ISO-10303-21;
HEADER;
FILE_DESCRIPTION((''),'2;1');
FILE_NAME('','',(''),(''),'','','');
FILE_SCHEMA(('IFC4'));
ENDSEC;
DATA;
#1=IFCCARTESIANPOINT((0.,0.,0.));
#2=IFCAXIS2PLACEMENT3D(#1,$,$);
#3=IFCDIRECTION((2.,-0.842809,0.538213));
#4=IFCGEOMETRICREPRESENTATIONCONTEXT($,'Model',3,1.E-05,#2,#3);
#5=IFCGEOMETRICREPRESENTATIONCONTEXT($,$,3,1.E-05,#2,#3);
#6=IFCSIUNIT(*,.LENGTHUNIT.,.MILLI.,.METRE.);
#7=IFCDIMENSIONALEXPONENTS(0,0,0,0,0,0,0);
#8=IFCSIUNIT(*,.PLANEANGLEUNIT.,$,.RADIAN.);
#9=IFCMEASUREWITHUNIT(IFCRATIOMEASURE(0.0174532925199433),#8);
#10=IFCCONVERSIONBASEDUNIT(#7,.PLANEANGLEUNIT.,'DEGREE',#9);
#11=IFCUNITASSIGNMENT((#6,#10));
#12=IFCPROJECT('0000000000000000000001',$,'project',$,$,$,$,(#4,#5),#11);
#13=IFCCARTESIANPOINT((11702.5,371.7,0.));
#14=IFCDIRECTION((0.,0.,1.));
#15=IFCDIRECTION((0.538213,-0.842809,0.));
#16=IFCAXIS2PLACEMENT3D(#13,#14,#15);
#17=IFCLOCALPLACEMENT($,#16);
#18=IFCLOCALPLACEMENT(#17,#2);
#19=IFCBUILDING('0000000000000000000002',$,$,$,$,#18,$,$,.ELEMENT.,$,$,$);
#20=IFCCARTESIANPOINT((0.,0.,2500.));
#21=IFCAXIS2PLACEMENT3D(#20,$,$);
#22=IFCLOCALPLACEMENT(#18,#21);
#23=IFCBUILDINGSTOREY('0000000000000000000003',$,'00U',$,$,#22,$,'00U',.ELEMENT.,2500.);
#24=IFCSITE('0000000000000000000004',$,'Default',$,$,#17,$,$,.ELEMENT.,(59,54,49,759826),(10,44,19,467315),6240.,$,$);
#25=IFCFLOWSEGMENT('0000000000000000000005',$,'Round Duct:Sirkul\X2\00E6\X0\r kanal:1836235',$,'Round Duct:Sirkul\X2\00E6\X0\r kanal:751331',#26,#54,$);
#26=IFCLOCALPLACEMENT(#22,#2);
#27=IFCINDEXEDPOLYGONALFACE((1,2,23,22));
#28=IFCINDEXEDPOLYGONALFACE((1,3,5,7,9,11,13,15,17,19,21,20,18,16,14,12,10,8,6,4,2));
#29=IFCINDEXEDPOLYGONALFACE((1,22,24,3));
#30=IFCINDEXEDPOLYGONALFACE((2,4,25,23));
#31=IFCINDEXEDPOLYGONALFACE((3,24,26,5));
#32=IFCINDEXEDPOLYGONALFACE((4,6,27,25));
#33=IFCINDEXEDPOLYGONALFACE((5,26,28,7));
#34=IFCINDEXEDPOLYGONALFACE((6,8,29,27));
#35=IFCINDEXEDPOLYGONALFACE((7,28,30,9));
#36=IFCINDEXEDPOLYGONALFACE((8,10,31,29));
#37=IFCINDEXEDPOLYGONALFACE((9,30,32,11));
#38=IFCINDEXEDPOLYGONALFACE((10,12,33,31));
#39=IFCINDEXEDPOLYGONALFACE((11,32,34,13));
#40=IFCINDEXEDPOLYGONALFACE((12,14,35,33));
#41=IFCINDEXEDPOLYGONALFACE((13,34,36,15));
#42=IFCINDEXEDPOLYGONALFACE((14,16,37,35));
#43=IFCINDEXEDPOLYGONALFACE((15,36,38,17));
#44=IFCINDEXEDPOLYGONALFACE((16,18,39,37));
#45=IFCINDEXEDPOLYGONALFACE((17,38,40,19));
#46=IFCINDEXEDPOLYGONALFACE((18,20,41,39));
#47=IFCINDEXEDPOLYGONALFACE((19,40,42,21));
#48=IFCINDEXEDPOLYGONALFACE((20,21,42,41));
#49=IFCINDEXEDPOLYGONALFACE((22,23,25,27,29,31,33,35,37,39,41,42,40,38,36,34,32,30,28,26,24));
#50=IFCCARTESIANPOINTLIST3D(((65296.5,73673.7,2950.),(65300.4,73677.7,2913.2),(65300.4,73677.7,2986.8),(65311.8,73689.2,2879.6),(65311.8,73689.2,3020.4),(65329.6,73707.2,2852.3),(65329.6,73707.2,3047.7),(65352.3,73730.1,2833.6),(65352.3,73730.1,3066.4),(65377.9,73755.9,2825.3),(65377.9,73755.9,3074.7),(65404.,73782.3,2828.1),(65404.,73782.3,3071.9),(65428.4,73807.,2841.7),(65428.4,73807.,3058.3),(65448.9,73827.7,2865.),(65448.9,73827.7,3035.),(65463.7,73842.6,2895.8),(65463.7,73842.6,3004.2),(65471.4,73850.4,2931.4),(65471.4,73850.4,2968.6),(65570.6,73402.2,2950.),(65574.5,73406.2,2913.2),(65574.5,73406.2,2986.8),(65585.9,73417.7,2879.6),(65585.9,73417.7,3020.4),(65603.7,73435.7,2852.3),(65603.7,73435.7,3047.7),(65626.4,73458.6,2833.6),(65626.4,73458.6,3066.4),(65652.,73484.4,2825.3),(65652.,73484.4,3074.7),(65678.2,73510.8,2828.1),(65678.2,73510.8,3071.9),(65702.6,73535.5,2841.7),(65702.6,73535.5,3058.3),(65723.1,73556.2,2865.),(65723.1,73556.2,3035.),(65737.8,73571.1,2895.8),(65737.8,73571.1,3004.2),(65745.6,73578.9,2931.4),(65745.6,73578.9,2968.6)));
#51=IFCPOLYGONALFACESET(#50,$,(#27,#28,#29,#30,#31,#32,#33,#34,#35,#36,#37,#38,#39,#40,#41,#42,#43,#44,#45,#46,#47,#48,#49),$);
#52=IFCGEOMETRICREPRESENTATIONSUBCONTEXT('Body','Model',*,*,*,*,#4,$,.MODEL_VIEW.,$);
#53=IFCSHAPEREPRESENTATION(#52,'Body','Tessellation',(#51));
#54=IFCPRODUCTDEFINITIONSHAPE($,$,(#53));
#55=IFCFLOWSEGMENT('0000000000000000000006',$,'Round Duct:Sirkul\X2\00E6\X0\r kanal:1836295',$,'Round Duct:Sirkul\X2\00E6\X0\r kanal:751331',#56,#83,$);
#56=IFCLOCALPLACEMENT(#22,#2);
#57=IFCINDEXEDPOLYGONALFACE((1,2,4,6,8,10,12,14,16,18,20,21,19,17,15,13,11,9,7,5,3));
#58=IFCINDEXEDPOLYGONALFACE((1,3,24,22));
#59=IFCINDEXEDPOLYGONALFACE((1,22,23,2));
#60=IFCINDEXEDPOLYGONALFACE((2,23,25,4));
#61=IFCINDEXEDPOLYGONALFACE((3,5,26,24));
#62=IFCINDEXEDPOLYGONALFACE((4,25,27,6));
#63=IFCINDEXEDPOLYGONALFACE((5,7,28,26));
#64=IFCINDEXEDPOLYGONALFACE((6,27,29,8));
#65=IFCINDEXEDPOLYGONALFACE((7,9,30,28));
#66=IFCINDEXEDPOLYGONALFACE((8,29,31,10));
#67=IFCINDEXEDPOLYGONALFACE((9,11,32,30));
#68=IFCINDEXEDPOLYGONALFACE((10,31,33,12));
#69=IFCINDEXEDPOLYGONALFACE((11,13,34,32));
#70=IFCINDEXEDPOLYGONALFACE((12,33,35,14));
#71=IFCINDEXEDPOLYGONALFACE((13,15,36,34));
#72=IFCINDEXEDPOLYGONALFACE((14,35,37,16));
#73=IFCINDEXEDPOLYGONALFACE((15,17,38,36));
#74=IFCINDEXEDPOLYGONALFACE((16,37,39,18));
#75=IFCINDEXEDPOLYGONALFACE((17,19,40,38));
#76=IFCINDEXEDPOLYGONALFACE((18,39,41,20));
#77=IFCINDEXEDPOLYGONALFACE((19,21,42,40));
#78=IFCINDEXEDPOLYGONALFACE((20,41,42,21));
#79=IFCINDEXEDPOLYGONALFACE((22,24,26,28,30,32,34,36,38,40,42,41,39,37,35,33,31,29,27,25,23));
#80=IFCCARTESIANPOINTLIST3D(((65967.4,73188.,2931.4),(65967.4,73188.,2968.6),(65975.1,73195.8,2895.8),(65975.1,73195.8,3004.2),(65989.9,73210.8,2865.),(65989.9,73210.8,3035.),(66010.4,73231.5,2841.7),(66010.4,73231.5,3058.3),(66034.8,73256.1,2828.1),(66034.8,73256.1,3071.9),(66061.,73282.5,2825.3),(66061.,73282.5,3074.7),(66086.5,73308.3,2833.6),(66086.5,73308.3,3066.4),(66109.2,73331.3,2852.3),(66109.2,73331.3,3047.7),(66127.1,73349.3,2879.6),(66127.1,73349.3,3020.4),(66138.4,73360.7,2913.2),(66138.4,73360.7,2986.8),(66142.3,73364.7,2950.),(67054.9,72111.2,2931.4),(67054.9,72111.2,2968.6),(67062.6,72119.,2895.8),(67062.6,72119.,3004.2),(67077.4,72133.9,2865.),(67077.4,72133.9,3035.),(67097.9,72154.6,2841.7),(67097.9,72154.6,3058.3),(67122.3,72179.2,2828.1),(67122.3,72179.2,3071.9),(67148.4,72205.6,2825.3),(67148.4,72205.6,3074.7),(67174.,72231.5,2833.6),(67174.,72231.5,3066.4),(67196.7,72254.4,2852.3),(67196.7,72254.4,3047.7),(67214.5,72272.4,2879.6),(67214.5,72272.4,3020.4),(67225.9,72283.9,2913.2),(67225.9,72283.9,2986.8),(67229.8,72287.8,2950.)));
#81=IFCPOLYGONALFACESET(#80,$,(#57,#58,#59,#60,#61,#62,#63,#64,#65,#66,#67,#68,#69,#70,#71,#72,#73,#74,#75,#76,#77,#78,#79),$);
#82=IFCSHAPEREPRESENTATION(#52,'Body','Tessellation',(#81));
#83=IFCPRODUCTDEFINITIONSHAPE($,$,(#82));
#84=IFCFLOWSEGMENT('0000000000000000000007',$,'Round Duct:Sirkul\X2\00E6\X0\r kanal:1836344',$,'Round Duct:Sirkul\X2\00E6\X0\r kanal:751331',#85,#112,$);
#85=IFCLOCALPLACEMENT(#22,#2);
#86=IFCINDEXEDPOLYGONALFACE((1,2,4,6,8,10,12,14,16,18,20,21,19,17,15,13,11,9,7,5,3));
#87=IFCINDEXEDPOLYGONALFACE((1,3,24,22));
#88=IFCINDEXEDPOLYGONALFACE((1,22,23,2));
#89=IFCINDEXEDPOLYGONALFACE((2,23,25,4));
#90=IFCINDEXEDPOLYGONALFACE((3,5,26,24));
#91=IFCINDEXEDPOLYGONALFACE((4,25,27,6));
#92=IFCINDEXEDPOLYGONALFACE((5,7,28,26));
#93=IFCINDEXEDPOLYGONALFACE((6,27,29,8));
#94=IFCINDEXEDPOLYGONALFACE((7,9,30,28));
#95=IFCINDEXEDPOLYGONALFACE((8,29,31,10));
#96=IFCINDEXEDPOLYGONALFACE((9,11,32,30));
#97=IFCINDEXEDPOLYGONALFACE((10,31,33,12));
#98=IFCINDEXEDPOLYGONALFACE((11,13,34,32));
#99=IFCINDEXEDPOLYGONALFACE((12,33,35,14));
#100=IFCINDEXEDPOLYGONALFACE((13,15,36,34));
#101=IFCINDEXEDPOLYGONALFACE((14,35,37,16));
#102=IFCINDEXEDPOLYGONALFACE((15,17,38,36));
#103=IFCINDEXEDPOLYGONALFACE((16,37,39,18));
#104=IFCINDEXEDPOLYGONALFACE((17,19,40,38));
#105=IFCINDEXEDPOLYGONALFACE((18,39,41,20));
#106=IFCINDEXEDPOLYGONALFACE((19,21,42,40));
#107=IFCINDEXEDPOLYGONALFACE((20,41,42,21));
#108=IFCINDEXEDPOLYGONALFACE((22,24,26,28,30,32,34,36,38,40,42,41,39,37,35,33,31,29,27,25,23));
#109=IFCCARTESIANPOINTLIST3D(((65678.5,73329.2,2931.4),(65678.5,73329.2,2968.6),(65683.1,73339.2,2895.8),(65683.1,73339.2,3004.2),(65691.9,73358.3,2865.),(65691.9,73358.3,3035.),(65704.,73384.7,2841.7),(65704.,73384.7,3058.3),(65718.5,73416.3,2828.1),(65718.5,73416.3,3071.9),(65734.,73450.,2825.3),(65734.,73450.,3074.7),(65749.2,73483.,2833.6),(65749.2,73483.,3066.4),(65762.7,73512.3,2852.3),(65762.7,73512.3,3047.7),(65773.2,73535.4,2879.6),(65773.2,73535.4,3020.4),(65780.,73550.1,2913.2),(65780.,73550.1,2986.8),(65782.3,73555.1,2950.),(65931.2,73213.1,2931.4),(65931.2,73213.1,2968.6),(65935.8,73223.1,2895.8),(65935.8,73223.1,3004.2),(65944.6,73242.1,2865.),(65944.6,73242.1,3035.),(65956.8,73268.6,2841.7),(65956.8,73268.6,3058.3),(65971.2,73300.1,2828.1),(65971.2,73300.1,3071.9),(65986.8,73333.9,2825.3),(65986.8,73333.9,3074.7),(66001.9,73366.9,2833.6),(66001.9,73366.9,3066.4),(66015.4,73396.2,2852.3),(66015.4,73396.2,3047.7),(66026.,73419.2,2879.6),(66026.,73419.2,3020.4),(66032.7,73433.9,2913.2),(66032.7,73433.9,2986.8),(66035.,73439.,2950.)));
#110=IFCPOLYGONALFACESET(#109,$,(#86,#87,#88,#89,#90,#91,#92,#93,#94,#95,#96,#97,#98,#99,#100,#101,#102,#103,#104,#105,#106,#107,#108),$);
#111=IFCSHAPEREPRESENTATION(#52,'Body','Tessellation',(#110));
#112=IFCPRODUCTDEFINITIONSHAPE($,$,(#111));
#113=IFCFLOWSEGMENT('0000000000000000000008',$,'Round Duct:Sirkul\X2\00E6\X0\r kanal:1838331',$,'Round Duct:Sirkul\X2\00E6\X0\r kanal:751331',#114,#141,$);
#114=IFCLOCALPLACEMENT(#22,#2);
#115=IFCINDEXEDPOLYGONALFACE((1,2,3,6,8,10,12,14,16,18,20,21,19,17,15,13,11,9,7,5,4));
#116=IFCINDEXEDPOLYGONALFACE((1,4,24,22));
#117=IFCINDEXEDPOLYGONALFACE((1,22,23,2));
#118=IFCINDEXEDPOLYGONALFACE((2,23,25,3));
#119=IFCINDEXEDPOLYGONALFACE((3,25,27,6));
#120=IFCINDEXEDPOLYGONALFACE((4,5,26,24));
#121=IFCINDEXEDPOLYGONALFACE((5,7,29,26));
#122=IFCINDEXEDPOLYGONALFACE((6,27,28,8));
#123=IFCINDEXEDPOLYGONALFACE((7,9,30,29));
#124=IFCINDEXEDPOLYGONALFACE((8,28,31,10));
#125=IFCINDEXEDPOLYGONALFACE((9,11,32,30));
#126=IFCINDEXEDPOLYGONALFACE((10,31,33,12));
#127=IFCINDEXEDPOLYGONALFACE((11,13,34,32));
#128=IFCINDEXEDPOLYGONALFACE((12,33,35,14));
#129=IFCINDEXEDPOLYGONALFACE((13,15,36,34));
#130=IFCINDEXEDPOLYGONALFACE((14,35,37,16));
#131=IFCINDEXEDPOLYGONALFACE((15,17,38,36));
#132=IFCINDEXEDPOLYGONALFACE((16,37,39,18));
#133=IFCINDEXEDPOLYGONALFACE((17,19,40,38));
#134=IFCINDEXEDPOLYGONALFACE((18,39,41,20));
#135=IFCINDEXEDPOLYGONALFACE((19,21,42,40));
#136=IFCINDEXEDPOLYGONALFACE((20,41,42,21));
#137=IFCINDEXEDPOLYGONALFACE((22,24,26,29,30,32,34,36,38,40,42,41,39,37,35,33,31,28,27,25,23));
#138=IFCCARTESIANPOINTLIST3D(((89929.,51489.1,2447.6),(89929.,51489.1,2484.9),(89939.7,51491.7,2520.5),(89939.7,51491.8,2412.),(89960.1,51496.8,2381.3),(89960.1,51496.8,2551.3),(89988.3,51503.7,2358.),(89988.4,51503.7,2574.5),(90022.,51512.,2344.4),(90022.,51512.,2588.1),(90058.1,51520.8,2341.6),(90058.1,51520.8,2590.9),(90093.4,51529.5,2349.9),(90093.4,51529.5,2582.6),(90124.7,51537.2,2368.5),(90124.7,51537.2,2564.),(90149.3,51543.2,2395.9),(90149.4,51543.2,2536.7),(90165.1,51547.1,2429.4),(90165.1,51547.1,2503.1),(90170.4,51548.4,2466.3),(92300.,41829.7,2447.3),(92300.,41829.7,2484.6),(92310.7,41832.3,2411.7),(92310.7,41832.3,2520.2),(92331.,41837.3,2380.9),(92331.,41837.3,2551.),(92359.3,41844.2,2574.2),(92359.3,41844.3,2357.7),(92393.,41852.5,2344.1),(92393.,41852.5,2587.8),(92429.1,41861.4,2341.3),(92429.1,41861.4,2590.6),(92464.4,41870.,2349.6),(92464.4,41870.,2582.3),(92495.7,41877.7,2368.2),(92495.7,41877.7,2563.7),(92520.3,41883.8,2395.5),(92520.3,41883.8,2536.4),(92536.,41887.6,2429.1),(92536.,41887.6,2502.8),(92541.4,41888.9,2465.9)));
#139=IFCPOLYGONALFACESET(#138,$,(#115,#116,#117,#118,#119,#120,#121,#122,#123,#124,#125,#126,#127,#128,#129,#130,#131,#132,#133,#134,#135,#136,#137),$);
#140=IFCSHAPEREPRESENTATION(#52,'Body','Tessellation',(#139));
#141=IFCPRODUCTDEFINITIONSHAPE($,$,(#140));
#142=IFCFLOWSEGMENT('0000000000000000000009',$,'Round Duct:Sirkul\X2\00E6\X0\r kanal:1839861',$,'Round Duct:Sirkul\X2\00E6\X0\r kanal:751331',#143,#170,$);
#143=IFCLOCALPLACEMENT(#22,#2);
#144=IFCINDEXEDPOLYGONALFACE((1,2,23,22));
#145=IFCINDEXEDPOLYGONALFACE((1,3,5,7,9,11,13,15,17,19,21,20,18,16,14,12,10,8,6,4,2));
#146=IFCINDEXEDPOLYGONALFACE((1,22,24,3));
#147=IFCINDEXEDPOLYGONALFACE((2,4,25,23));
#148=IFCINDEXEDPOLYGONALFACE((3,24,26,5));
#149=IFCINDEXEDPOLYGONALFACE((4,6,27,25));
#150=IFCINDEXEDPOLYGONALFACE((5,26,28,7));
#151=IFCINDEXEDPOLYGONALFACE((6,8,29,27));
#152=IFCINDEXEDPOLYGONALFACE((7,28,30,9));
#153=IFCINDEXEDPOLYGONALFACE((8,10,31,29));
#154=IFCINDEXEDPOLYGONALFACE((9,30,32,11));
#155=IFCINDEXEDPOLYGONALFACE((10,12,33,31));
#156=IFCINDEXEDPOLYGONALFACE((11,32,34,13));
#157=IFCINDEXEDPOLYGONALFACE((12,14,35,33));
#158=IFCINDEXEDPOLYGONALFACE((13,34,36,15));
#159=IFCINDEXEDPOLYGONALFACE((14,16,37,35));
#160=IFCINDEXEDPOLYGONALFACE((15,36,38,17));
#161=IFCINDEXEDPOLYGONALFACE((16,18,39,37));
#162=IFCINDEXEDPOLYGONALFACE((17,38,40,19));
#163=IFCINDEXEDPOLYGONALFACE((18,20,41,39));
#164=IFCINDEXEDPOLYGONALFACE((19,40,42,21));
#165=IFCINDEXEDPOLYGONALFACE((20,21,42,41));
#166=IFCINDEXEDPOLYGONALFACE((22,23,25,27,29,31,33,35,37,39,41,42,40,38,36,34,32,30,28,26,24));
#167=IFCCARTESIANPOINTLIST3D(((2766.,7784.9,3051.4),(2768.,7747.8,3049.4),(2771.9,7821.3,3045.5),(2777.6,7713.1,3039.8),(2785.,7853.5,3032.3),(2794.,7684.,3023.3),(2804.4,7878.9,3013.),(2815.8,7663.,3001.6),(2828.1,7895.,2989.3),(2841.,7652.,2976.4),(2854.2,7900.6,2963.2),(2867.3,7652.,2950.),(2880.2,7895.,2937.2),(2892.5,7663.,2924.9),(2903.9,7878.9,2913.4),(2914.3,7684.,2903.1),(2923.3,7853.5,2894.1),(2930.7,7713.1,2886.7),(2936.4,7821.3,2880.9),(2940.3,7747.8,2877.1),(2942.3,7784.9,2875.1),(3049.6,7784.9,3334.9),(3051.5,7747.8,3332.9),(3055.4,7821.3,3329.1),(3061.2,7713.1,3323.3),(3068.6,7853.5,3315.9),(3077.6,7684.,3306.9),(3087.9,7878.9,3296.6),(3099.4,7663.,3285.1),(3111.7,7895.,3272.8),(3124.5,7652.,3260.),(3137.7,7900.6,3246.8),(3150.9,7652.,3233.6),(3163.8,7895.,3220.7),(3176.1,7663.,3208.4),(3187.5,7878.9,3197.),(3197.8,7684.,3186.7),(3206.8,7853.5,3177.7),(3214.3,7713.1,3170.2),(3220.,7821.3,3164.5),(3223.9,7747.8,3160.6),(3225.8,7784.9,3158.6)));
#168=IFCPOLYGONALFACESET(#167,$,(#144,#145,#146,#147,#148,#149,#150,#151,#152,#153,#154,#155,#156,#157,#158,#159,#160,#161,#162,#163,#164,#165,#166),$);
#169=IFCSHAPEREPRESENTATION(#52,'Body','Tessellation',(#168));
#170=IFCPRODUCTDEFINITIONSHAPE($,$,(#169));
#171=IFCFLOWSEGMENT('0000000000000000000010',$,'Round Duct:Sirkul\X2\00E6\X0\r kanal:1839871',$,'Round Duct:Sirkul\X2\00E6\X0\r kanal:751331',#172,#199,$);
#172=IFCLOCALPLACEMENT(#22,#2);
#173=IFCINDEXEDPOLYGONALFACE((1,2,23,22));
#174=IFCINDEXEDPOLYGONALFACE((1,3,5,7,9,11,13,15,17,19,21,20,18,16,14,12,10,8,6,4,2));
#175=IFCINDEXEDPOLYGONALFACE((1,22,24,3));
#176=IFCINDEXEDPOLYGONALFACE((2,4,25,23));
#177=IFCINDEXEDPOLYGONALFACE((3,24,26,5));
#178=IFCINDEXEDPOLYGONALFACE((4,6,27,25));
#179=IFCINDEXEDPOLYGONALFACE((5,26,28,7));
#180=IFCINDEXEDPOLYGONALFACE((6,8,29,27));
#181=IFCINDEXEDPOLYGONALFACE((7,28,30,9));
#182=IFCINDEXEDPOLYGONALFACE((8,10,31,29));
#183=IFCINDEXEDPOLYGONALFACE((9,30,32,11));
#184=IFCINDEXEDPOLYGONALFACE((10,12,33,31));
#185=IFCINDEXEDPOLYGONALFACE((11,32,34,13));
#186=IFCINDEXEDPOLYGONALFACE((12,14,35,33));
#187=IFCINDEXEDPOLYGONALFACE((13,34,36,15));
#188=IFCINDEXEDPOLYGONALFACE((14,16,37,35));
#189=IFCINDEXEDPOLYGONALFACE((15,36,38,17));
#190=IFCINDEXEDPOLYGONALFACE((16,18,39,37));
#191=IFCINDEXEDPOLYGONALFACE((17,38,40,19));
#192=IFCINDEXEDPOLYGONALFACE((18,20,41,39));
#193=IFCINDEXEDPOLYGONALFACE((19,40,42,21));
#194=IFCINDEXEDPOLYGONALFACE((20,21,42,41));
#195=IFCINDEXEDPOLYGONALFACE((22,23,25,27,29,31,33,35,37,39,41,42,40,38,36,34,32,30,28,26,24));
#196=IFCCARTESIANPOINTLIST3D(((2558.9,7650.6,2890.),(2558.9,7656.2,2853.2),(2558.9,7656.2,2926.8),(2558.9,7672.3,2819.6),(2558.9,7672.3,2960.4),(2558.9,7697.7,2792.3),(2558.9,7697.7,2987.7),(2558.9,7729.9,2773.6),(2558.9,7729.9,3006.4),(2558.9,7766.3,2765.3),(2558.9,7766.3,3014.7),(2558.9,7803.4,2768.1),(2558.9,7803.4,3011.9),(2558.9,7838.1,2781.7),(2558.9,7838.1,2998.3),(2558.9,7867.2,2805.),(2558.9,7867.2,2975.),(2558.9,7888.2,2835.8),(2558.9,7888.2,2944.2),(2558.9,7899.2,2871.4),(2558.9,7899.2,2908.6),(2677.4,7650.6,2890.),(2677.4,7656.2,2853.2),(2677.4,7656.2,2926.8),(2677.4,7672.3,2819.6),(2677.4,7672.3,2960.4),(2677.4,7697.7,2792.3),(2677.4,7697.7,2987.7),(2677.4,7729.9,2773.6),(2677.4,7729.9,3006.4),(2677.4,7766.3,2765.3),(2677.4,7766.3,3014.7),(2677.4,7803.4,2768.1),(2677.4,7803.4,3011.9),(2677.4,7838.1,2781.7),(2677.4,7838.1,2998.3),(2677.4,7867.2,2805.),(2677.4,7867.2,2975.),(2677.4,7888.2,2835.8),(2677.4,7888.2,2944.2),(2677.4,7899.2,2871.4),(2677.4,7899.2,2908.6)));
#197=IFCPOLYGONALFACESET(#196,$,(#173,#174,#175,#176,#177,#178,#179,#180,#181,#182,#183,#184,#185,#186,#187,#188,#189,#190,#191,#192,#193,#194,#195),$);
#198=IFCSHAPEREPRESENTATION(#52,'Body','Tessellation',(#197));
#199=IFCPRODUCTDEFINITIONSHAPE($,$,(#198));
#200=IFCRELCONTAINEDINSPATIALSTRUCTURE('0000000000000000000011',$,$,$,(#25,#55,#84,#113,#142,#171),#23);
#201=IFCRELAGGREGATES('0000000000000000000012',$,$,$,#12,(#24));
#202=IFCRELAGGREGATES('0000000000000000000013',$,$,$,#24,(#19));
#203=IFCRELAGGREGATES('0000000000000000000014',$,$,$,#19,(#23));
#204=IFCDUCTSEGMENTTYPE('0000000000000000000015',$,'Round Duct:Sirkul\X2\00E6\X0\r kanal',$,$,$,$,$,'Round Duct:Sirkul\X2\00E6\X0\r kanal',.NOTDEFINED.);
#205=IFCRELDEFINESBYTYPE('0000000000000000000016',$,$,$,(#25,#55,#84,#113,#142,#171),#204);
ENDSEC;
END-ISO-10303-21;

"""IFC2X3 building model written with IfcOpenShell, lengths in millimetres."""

from ifc_helpers import new_model, entity, si_unit, converted_unit, direction, frame, frame_2d, origin, origin_2d_with_axis, place, context, subcontext, project, spatial, circle, extrude, type_object, element, save


model = new_model("IFC2X3")

# Units and contexts
model_context = context("Model", 3, precision=1e-05, world=origin(), true_north=direction((2.0, -0.842809, 0.538213)))
context_of_model = context(None, 3, precision=1e-05, world=origin(), true_north=direction((2.0, -0.842809, 0.538213)))
body_context = subcontext(model_context, "Body", "Model", "MODEL_VIEW")
ifc_project = project(units=[si_unit("LENGTHUNIT", "METRE", prefix="MILLI"), converted_unit("PLANEANGLEUNIT", "DEGREE", entity("IfcRatioMeasure", 0.0174532925199433), si_unit("PLANEANGLEUNIT", "RADIAN"), dimensions=[0, 0, 0, 0, 0, 0, 0])], contexts=[model_context, context_of_model])

# Site, building, storey
site_placement = place(None, frame((11702.5, 371.7, 0.0), z_axis=(0.0, 0.0, 1.0), x_axis=(0.538213, -0.842809, 0.0)))
site = spatial("IfcSite", under=ifc_project, at=site_placement, Name="Default", CompositionType="ELEMENT", RefLatitude=(59, 54, 49, 759826), RefLongitude=(10, 44, 19, 467315), RefElevation=6240.0)
building_placement = place(site_placement, origin())
building = spatial("IfcBuilding", under=site, at=building_placement, CompositionType="ELEMENT")
storey_placement = place(building_placement, frame((0.0, 0.0, 2500.0)))
storey = spatial("IfcBuildingStorey", under=building, at=storey_placement, Name="00U", LongName="00U", CompositionType="ELEMENT", Elevation=2500.0)

# Flow segments
duct_segment_type = type_object("IfcDuctSegmentType", Name="Round Duct:Sirkulær kanal", ElementType="Round Duct:Sirkulær kanal", PredefinedType="NOTDEFINED")
flow_segment_1_placement = place(storey_placement, origin())
element("IfcFlowSegment", 1, at=flow_segment_1_placement, inside=storey, type_object=duct_segment_type, Name="Round Duct:Sirkulær kanal:1836235", ObjectType="Round Duct:Sirkulær kanal:751331", context=body_context, shape_type="SweptSolid", body=[
    extrude(circle(Radius=125.0, at=origin_2d_with_axis()), frame((65658.6, 73491.1, 2950.0), z_axis=(-0.710554, 0.703643, 0.0), x_axis=(-0.703643, -0.710554, 0.0)), (0.0, 0.0, 1.0), 385.8),
])
flow_segment_2_placement = place(storey_placement, origin())
element("IfcFlowSegment", 2, at=flow_segment_2_placement, inside=storey, type_object=duct_segment_type, Name="Round Duct:Sirkulær kanal:1836295", ObjectType="Round Duct:Sirkulær kanal:751331", context=body_context, shape_type="SweptSolid", body=[
    extrude(circle(Radius=125.0, at=origin_2d_with_axis()), frame((67141.8, 72199.0, 2950.0), z_axis=(-0.710554, 0.703643, 0.0), x_axis=(0.703643, 0.710554, 0.0)), (0.0, 0.0, 1.0), 1530.4),
])
flow_segment_3_placement = place(storey_placement, origin())
element("IfcFlowSegment", 3, at=flow_segment_3_placement, inside=storey, type_object=duct_segment_type, Name="Round Duct:Sirkulær kanal:1836344", ObjectType="Round Duct:Sirkulær kanal:751331", context=body_context, shape_type="SweptSolid", body=[
    extrude(circle(Radius=125.0, at=origin_2d_with_axis()), frame((65730.1, 73441.5, 2950.0), z_axis=(0.90867, -0.417515, 0.0), x_axis=(0.417515, 0.90867, 0.0)), (0.0, 0.0, 1.0), 278.1),
])
flow_segment_4_placement = place(storey_placement, origin())
element("IfcFlowSegment", 4, at=flow_segment_4_placement, inside=storey, type_object=duct_segment_type, Name="Round Duct:Sirkulær kanal:1838331", ObjectType="Round Duct:Sirkulær kanal:751331", context=body_context, shape_type="SweptSolid", body=[
    extrude(circle(Radius=125.0, at=origin_2d_with_axis()), frame((90049.0, 51518.6, 2466.3), z_axis=(0.238381, -0.971172, -0.000034), x_axis=(0.971172, 0.238381, 0.0)), (0.0, 0.0, 1.0), 9946.2),
])
flow_segment_5_placement = place(storey_placement, origin())
element("IfcFlowSegment", 5, at=flow_segment_5_placement, inside=storey, type_object=duct_segment_type, Name="Round Duct:Sirkulær kanal:1839861", ObjectType="Round Duct:Sirkulær kanal:751331", context=body_context, shape_type="SweptSolid", body=[
    extrude(circle(Radius=125.0, at=frame_2d((0.0, 0.0), x_axis=(1.0, 0.0))), frame((2854.2, 7775.6, 2963.2), z_axis=(0.707107, 0.0, 0.707107), x_axis=(0.0, 1.0, 0.0)), (0.0, 0.0, 1.0), 401.0),
])
flow_segment_6_placement = place(storey_placement, origin())
element("IfcFlowSegment", 6, at=flow_segment_6_placement, inside=storey, type_object=duct_segment_type, Name="Round Duct:Sirkulær kanal:1839871", ObjectType="Round Duct:Sirkulær kanal:751331", context=body_context, shape_type="SweptSolid", body=[
    extrude(circle(Radius=125.0, at=origin_2d_with_axis()), frame((2558.9, 7775.6, 2890.0), z_axis=(1.0, 0.0, 0.0), x_axis=(0.0, -1.0, 0.0)), (0.0, 0.0, 1.0), 118.4),
])

save(model, "model.ifc")
